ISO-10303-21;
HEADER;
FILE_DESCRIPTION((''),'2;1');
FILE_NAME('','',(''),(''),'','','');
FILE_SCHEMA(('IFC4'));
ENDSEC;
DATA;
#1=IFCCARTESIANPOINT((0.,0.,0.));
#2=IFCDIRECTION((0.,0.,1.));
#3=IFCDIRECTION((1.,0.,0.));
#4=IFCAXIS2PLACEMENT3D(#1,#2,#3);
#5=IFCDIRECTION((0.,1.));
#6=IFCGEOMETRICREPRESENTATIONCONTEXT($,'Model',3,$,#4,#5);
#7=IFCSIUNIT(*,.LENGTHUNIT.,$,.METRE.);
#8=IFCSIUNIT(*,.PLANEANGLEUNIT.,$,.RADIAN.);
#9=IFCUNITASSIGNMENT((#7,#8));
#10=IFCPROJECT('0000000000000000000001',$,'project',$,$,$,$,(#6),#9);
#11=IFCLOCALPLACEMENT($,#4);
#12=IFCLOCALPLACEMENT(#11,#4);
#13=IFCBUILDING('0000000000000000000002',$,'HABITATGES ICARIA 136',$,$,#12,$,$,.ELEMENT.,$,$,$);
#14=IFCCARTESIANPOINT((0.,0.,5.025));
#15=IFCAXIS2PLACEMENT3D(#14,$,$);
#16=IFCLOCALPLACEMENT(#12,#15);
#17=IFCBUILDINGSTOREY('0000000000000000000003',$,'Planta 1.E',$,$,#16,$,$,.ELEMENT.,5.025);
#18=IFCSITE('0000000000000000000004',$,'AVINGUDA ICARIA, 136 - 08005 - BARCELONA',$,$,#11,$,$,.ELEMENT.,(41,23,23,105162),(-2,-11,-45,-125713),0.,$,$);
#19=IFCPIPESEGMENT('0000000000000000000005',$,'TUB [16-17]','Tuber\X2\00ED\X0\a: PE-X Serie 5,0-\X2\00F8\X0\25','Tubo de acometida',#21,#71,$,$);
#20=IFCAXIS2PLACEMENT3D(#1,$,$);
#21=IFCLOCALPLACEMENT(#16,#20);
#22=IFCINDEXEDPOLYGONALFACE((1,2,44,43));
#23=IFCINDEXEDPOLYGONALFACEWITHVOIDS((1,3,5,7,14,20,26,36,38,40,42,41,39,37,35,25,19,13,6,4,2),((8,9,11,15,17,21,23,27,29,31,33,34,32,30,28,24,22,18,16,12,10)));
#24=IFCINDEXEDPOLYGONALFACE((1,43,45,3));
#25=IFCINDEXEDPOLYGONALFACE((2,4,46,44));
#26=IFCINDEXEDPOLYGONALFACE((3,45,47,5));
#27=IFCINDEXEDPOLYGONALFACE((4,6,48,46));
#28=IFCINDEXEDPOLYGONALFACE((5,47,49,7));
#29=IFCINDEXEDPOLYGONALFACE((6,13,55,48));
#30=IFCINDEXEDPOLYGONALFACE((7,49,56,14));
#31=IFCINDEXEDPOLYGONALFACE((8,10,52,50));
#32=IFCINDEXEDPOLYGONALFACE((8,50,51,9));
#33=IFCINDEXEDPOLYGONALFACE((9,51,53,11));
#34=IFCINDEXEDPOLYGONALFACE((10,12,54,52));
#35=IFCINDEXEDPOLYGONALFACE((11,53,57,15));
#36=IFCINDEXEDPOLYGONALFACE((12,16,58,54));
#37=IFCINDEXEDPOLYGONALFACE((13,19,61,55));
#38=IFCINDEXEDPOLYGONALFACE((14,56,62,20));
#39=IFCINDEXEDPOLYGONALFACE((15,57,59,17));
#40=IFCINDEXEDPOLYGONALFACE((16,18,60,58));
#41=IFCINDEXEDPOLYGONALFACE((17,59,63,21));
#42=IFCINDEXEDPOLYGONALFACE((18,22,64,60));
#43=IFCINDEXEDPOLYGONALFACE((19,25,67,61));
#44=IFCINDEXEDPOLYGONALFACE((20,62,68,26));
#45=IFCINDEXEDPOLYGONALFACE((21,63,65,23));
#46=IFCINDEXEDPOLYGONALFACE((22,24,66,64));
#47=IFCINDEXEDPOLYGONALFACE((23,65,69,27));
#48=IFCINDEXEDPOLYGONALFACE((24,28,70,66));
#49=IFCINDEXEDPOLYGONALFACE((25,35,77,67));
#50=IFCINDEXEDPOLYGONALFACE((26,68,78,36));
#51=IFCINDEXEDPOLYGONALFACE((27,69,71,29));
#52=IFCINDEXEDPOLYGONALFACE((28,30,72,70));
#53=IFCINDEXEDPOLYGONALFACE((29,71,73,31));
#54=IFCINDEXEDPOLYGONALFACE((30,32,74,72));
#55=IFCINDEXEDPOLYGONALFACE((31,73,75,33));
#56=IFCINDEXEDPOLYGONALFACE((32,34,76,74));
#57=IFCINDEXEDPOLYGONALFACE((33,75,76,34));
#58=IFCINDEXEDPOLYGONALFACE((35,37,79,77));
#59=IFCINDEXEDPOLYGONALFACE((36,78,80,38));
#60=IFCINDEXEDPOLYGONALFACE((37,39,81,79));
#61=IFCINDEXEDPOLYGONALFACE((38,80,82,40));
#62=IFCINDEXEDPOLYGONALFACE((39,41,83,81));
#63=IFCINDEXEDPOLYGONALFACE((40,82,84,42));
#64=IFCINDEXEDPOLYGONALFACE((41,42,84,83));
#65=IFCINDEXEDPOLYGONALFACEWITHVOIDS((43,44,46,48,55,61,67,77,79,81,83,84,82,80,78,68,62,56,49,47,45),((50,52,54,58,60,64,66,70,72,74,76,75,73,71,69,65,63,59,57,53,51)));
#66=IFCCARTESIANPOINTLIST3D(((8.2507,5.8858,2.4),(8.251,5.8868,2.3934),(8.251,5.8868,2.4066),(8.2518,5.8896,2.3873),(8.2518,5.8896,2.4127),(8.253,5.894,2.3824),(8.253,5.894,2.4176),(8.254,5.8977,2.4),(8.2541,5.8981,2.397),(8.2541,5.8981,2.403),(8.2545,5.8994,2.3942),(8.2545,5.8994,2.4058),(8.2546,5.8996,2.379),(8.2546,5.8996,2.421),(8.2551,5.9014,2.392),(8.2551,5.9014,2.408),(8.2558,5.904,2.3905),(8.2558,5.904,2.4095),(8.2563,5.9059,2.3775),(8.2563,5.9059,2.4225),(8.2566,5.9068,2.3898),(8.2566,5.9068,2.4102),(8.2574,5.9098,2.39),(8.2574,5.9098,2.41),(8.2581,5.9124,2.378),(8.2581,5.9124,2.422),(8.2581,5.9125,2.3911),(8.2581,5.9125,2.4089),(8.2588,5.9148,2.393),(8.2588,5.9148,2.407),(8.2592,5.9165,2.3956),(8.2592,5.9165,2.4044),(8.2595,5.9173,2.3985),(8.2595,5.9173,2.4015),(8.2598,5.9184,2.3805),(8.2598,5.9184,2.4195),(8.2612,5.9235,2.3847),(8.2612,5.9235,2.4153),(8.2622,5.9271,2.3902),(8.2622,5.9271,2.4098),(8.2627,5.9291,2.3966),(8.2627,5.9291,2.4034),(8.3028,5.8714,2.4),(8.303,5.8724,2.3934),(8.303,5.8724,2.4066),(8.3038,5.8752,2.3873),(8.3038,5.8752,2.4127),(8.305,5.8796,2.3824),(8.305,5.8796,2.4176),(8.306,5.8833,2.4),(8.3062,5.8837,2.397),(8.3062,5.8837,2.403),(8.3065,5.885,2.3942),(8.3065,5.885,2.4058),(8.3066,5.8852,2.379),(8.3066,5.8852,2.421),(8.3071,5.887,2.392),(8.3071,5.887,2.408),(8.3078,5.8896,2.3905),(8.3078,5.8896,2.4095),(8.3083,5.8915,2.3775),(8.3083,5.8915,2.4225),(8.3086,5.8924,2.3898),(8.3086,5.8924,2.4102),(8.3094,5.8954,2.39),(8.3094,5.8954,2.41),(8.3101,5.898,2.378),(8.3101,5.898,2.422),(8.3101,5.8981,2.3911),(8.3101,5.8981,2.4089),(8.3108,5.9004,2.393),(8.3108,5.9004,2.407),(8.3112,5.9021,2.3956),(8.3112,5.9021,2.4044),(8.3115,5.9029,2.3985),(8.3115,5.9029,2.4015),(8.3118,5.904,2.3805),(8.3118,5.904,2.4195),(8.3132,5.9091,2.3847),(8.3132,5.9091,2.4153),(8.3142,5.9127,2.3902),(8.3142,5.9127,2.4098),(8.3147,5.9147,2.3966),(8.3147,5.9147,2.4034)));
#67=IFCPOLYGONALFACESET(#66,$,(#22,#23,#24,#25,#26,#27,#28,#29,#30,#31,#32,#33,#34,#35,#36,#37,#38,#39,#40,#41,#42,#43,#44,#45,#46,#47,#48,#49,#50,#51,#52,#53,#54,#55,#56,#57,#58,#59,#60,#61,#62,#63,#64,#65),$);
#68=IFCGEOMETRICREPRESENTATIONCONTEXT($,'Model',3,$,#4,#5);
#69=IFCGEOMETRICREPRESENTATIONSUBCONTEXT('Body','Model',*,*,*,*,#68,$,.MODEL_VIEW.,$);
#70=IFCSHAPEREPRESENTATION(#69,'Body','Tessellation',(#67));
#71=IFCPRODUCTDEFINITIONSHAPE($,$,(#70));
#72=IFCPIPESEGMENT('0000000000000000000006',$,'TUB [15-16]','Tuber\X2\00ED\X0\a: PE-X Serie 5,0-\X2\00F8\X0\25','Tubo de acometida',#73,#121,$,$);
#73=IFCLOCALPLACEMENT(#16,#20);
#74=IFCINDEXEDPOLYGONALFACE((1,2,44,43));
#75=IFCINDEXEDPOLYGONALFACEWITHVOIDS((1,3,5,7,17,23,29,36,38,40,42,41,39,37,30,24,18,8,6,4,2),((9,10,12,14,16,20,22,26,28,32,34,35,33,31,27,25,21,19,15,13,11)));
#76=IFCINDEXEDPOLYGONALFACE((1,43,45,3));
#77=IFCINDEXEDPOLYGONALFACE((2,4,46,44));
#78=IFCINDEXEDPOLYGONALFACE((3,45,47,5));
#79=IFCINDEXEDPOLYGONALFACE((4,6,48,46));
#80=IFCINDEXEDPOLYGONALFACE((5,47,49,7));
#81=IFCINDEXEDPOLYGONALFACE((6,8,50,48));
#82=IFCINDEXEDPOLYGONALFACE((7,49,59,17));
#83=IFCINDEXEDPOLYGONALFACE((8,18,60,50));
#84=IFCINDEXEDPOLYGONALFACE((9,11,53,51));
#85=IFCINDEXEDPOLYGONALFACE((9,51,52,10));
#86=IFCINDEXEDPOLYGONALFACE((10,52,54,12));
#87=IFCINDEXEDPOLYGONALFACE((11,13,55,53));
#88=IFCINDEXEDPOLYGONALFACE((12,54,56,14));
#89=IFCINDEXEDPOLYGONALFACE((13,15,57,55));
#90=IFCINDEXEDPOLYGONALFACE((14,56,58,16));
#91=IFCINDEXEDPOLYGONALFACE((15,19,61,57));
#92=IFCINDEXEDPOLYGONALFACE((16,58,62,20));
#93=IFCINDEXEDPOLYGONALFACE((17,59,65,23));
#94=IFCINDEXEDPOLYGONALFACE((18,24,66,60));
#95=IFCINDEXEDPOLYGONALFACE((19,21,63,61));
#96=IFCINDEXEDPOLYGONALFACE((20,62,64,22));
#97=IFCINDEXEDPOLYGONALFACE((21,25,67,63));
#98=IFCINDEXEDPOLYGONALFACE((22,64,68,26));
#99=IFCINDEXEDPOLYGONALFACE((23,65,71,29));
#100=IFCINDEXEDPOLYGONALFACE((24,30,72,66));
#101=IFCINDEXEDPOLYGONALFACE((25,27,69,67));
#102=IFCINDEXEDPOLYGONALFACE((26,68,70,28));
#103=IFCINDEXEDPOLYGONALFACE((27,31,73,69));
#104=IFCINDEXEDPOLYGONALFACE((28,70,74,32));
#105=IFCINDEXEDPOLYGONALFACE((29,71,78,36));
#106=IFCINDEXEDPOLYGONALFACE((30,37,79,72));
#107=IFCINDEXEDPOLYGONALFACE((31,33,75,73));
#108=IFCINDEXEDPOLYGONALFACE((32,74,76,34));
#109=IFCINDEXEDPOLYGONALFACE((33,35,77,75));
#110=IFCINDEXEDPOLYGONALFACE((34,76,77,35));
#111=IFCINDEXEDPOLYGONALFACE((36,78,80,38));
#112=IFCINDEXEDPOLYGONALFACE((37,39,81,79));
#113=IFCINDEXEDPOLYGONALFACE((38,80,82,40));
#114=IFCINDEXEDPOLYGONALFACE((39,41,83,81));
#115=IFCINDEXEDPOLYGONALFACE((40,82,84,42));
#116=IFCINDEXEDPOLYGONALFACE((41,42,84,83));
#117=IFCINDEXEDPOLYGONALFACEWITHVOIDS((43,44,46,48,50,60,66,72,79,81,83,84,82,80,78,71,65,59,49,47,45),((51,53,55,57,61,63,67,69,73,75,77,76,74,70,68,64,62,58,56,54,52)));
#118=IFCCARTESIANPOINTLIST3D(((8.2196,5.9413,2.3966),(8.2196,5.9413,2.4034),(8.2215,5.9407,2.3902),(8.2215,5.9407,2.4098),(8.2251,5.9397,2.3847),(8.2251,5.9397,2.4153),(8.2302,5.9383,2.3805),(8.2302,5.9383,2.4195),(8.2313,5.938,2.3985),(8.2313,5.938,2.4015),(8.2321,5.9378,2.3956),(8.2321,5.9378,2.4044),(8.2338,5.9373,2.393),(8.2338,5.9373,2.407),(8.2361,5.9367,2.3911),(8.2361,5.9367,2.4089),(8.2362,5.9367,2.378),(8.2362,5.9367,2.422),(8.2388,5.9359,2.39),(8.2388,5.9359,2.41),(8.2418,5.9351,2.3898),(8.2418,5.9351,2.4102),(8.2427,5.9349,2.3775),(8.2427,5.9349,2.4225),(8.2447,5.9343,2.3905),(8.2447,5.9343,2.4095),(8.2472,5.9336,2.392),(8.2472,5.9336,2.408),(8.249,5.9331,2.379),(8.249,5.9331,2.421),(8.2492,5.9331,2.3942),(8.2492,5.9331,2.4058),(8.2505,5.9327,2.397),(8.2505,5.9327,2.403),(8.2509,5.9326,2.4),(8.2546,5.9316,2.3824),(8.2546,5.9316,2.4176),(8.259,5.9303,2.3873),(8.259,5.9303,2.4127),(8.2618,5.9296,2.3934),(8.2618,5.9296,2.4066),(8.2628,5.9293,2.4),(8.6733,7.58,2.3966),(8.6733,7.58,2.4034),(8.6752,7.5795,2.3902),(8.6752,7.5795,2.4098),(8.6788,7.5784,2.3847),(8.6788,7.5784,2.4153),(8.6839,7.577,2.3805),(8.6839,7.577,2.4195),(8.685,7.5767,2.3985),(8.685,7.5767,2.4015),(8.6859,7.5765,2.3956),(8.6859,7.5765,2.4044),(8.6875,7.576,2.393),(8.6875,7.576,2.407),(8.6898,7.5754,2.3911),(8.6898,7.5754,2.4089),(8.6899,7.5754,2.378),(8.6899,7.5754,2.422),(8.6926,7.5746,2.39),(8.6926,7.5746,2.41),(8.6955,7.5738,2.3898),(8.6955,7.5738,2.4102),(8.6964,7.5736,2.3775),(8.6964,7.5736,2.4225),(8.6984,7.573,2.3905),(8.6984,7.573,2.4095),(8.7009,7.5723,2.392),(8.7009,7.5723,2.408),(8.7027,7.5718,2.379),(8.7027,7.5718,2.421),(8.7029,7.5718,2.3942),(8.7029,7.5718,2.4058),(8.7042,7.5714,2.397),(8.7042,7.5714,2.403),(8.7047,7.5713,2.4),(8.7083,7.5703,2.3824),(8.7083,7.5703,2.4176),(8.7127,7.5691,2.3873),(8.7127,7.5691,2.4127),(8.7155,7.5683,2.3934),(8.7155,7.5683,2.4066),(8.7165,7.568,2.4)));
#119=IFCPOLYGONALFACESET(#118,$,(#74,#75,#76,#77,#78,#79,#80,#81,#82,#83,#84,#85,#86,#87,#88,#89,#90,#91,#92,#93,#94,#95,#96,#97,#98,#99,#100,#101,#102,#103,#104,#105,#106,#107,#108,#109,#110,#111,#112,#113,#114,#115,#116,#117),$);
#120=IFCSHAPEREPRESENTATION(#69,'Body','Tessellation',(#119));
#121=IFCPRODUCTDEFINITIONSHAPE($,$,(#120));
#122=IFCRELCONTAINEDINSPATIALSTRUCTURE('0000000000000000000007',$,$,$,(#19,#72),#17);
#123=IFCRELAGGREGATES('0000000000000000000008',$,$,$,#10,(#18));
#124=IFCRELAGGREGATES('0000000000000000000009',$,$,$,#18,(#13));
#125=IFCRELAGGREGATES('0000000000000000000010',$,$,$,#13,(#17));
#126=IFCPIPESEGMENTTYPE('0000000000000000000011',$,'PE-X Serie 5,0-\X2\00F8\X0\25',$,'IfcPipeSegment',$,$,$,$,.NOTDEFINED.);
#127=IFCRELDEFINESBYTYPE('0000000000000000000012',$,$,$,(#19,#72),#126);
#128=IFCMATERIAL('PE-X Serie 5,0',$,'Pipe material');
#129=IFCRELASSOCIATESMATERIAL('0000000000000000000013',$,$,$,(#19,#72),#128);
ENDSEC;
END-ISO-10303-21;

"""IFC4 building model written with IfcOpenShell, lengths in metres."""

from ifc_helpers import new_model, si_unit, direction, frame, origin_with_axes, origin_2d_with_axis, place, context, subcontext, project, spatial, hollow_circle, extrude, material, type_object, element, save


model = new_model("IFC4")

# Units and contexts
model_context_1 = context("Model", 3, world=origin_with_axes(), true_north=direction((0.0, 1.0)))
model_context_2 = context("Model", 3, world=origin_with_axes(), true_north=direction((0.0, 1.0)))
body_context_1 = subcontext(model_context_2, "Body", "Model", "MODEL_VIEW")
ifc_project = project(units=[si_unit("LENGTHUNIT", "METRE"), si_unit("PLANEANGLEUNIT", "RADIAN")], contexts=[model_context_1])

# Site, building, storey
site_placement = place(None, origin_with_axes())
site = spatial("IfcSite", under=ifc_project, at=site_placement, Name="AVINGUDA ICARIA, 136 - 08005 - BARCELONA", CompositionType="ELEMENT", RefLatitude=(41, 23, 23, 105162), RefLongitude=(-2, -11, -45, -125713), RefElevation=0.0)
building_placement = place(site_placement, origin_with_axes())
building = spatial("IfcBuilding", under=site, at=building_placement, Name="HABITATGES ICARIA 136", CompositionType="ELEMENT")
storey_placement = place(building_placement, frame((0.0, 0.0, 5.025)))
storey = spatial("IfcBuildingStorey", under=building, at=storey_placement, Name="Planta 1.E", CompositionType="ELEMENT", Elevation=5.025)

# Shared definitions
ifc_material_1 = material(Name="PE-X Serie 5,0", Category="Pipe material")
placement_1 = place(None, origin_with_axes())
placement_2 = place(placement_1, origin_with_axes())
placement_3 = place(placement_2, frame((0.0, 0.0, 5.025)))

# Pipe segments
pipe_segment_type_1 = type_object("IfcPipeSegmentType", Name="PE-X Serie 5,0-ø25", ApplicableOccurrence="IfcPipeSegment", PredefinedType="NOTDEFINED")
pipe_segment_1_placement = place(placement_3, frame((0.0, 0.0, -5.025), z_axis=(0.0, 0.0, 1.0), x_axis=(1.0, 0.0, 0.0)))
element("IfcPipeSegment", 1, at=pipe_segment_1_placement, inside=storey, type_object=pipe_segment_type_1, material=ifc_material_1, Name="TUB [16-17]", Description="Tubería: PE-X Serie 5,0-ø25", ObjectType="Tubo de acometida", context=body_context_1, shape_type="SweptSolid", body=[
    extrude(hollow_circle(Radius=0.0226, WallThickness=0.0123, at=origin_2d_with_axis()), frame((8.3088, 5.8932, 7.425), z_axis=(-0.96374, 0.266843, 0.0), x_axis=(-0.266843, -0.96374, 0.0)), (0.0, 0.0, 1.0), 0.054),
])
pipe_segment_2_placement = place(placement_3, frame((0.0, 0.0, -5.025), z_axis=(0.0, 0.0, 1.0), x_axis=(1.0, 0.0, 0.0)))
element("IfcPipeSegment", 2, at=pipe_segment_2_placement, inside=storey, type_object=pipe_segment_type_1, material=ifc_material_1, Name="TUB [15-16]", Description="Tubería: PE-X Serie 5,0-ø25", ObjectType="Tubo de acometida", context=body_context_1, shape_type="SweptSolid", body=[
    extrude(hollow_circle(Radius=0.0226, WallThickness=0.0123, at=origin_2d_with_axis()), frame((8.6948, 7.574, 7.425), z_axis=(-0.266843, -0.96374, 0.0), x_axis=(0.96374, -0.266843, 0.0)), (0.0, 0.0, 1.0), 1.7004),
])

save(model, "model.ifc")
